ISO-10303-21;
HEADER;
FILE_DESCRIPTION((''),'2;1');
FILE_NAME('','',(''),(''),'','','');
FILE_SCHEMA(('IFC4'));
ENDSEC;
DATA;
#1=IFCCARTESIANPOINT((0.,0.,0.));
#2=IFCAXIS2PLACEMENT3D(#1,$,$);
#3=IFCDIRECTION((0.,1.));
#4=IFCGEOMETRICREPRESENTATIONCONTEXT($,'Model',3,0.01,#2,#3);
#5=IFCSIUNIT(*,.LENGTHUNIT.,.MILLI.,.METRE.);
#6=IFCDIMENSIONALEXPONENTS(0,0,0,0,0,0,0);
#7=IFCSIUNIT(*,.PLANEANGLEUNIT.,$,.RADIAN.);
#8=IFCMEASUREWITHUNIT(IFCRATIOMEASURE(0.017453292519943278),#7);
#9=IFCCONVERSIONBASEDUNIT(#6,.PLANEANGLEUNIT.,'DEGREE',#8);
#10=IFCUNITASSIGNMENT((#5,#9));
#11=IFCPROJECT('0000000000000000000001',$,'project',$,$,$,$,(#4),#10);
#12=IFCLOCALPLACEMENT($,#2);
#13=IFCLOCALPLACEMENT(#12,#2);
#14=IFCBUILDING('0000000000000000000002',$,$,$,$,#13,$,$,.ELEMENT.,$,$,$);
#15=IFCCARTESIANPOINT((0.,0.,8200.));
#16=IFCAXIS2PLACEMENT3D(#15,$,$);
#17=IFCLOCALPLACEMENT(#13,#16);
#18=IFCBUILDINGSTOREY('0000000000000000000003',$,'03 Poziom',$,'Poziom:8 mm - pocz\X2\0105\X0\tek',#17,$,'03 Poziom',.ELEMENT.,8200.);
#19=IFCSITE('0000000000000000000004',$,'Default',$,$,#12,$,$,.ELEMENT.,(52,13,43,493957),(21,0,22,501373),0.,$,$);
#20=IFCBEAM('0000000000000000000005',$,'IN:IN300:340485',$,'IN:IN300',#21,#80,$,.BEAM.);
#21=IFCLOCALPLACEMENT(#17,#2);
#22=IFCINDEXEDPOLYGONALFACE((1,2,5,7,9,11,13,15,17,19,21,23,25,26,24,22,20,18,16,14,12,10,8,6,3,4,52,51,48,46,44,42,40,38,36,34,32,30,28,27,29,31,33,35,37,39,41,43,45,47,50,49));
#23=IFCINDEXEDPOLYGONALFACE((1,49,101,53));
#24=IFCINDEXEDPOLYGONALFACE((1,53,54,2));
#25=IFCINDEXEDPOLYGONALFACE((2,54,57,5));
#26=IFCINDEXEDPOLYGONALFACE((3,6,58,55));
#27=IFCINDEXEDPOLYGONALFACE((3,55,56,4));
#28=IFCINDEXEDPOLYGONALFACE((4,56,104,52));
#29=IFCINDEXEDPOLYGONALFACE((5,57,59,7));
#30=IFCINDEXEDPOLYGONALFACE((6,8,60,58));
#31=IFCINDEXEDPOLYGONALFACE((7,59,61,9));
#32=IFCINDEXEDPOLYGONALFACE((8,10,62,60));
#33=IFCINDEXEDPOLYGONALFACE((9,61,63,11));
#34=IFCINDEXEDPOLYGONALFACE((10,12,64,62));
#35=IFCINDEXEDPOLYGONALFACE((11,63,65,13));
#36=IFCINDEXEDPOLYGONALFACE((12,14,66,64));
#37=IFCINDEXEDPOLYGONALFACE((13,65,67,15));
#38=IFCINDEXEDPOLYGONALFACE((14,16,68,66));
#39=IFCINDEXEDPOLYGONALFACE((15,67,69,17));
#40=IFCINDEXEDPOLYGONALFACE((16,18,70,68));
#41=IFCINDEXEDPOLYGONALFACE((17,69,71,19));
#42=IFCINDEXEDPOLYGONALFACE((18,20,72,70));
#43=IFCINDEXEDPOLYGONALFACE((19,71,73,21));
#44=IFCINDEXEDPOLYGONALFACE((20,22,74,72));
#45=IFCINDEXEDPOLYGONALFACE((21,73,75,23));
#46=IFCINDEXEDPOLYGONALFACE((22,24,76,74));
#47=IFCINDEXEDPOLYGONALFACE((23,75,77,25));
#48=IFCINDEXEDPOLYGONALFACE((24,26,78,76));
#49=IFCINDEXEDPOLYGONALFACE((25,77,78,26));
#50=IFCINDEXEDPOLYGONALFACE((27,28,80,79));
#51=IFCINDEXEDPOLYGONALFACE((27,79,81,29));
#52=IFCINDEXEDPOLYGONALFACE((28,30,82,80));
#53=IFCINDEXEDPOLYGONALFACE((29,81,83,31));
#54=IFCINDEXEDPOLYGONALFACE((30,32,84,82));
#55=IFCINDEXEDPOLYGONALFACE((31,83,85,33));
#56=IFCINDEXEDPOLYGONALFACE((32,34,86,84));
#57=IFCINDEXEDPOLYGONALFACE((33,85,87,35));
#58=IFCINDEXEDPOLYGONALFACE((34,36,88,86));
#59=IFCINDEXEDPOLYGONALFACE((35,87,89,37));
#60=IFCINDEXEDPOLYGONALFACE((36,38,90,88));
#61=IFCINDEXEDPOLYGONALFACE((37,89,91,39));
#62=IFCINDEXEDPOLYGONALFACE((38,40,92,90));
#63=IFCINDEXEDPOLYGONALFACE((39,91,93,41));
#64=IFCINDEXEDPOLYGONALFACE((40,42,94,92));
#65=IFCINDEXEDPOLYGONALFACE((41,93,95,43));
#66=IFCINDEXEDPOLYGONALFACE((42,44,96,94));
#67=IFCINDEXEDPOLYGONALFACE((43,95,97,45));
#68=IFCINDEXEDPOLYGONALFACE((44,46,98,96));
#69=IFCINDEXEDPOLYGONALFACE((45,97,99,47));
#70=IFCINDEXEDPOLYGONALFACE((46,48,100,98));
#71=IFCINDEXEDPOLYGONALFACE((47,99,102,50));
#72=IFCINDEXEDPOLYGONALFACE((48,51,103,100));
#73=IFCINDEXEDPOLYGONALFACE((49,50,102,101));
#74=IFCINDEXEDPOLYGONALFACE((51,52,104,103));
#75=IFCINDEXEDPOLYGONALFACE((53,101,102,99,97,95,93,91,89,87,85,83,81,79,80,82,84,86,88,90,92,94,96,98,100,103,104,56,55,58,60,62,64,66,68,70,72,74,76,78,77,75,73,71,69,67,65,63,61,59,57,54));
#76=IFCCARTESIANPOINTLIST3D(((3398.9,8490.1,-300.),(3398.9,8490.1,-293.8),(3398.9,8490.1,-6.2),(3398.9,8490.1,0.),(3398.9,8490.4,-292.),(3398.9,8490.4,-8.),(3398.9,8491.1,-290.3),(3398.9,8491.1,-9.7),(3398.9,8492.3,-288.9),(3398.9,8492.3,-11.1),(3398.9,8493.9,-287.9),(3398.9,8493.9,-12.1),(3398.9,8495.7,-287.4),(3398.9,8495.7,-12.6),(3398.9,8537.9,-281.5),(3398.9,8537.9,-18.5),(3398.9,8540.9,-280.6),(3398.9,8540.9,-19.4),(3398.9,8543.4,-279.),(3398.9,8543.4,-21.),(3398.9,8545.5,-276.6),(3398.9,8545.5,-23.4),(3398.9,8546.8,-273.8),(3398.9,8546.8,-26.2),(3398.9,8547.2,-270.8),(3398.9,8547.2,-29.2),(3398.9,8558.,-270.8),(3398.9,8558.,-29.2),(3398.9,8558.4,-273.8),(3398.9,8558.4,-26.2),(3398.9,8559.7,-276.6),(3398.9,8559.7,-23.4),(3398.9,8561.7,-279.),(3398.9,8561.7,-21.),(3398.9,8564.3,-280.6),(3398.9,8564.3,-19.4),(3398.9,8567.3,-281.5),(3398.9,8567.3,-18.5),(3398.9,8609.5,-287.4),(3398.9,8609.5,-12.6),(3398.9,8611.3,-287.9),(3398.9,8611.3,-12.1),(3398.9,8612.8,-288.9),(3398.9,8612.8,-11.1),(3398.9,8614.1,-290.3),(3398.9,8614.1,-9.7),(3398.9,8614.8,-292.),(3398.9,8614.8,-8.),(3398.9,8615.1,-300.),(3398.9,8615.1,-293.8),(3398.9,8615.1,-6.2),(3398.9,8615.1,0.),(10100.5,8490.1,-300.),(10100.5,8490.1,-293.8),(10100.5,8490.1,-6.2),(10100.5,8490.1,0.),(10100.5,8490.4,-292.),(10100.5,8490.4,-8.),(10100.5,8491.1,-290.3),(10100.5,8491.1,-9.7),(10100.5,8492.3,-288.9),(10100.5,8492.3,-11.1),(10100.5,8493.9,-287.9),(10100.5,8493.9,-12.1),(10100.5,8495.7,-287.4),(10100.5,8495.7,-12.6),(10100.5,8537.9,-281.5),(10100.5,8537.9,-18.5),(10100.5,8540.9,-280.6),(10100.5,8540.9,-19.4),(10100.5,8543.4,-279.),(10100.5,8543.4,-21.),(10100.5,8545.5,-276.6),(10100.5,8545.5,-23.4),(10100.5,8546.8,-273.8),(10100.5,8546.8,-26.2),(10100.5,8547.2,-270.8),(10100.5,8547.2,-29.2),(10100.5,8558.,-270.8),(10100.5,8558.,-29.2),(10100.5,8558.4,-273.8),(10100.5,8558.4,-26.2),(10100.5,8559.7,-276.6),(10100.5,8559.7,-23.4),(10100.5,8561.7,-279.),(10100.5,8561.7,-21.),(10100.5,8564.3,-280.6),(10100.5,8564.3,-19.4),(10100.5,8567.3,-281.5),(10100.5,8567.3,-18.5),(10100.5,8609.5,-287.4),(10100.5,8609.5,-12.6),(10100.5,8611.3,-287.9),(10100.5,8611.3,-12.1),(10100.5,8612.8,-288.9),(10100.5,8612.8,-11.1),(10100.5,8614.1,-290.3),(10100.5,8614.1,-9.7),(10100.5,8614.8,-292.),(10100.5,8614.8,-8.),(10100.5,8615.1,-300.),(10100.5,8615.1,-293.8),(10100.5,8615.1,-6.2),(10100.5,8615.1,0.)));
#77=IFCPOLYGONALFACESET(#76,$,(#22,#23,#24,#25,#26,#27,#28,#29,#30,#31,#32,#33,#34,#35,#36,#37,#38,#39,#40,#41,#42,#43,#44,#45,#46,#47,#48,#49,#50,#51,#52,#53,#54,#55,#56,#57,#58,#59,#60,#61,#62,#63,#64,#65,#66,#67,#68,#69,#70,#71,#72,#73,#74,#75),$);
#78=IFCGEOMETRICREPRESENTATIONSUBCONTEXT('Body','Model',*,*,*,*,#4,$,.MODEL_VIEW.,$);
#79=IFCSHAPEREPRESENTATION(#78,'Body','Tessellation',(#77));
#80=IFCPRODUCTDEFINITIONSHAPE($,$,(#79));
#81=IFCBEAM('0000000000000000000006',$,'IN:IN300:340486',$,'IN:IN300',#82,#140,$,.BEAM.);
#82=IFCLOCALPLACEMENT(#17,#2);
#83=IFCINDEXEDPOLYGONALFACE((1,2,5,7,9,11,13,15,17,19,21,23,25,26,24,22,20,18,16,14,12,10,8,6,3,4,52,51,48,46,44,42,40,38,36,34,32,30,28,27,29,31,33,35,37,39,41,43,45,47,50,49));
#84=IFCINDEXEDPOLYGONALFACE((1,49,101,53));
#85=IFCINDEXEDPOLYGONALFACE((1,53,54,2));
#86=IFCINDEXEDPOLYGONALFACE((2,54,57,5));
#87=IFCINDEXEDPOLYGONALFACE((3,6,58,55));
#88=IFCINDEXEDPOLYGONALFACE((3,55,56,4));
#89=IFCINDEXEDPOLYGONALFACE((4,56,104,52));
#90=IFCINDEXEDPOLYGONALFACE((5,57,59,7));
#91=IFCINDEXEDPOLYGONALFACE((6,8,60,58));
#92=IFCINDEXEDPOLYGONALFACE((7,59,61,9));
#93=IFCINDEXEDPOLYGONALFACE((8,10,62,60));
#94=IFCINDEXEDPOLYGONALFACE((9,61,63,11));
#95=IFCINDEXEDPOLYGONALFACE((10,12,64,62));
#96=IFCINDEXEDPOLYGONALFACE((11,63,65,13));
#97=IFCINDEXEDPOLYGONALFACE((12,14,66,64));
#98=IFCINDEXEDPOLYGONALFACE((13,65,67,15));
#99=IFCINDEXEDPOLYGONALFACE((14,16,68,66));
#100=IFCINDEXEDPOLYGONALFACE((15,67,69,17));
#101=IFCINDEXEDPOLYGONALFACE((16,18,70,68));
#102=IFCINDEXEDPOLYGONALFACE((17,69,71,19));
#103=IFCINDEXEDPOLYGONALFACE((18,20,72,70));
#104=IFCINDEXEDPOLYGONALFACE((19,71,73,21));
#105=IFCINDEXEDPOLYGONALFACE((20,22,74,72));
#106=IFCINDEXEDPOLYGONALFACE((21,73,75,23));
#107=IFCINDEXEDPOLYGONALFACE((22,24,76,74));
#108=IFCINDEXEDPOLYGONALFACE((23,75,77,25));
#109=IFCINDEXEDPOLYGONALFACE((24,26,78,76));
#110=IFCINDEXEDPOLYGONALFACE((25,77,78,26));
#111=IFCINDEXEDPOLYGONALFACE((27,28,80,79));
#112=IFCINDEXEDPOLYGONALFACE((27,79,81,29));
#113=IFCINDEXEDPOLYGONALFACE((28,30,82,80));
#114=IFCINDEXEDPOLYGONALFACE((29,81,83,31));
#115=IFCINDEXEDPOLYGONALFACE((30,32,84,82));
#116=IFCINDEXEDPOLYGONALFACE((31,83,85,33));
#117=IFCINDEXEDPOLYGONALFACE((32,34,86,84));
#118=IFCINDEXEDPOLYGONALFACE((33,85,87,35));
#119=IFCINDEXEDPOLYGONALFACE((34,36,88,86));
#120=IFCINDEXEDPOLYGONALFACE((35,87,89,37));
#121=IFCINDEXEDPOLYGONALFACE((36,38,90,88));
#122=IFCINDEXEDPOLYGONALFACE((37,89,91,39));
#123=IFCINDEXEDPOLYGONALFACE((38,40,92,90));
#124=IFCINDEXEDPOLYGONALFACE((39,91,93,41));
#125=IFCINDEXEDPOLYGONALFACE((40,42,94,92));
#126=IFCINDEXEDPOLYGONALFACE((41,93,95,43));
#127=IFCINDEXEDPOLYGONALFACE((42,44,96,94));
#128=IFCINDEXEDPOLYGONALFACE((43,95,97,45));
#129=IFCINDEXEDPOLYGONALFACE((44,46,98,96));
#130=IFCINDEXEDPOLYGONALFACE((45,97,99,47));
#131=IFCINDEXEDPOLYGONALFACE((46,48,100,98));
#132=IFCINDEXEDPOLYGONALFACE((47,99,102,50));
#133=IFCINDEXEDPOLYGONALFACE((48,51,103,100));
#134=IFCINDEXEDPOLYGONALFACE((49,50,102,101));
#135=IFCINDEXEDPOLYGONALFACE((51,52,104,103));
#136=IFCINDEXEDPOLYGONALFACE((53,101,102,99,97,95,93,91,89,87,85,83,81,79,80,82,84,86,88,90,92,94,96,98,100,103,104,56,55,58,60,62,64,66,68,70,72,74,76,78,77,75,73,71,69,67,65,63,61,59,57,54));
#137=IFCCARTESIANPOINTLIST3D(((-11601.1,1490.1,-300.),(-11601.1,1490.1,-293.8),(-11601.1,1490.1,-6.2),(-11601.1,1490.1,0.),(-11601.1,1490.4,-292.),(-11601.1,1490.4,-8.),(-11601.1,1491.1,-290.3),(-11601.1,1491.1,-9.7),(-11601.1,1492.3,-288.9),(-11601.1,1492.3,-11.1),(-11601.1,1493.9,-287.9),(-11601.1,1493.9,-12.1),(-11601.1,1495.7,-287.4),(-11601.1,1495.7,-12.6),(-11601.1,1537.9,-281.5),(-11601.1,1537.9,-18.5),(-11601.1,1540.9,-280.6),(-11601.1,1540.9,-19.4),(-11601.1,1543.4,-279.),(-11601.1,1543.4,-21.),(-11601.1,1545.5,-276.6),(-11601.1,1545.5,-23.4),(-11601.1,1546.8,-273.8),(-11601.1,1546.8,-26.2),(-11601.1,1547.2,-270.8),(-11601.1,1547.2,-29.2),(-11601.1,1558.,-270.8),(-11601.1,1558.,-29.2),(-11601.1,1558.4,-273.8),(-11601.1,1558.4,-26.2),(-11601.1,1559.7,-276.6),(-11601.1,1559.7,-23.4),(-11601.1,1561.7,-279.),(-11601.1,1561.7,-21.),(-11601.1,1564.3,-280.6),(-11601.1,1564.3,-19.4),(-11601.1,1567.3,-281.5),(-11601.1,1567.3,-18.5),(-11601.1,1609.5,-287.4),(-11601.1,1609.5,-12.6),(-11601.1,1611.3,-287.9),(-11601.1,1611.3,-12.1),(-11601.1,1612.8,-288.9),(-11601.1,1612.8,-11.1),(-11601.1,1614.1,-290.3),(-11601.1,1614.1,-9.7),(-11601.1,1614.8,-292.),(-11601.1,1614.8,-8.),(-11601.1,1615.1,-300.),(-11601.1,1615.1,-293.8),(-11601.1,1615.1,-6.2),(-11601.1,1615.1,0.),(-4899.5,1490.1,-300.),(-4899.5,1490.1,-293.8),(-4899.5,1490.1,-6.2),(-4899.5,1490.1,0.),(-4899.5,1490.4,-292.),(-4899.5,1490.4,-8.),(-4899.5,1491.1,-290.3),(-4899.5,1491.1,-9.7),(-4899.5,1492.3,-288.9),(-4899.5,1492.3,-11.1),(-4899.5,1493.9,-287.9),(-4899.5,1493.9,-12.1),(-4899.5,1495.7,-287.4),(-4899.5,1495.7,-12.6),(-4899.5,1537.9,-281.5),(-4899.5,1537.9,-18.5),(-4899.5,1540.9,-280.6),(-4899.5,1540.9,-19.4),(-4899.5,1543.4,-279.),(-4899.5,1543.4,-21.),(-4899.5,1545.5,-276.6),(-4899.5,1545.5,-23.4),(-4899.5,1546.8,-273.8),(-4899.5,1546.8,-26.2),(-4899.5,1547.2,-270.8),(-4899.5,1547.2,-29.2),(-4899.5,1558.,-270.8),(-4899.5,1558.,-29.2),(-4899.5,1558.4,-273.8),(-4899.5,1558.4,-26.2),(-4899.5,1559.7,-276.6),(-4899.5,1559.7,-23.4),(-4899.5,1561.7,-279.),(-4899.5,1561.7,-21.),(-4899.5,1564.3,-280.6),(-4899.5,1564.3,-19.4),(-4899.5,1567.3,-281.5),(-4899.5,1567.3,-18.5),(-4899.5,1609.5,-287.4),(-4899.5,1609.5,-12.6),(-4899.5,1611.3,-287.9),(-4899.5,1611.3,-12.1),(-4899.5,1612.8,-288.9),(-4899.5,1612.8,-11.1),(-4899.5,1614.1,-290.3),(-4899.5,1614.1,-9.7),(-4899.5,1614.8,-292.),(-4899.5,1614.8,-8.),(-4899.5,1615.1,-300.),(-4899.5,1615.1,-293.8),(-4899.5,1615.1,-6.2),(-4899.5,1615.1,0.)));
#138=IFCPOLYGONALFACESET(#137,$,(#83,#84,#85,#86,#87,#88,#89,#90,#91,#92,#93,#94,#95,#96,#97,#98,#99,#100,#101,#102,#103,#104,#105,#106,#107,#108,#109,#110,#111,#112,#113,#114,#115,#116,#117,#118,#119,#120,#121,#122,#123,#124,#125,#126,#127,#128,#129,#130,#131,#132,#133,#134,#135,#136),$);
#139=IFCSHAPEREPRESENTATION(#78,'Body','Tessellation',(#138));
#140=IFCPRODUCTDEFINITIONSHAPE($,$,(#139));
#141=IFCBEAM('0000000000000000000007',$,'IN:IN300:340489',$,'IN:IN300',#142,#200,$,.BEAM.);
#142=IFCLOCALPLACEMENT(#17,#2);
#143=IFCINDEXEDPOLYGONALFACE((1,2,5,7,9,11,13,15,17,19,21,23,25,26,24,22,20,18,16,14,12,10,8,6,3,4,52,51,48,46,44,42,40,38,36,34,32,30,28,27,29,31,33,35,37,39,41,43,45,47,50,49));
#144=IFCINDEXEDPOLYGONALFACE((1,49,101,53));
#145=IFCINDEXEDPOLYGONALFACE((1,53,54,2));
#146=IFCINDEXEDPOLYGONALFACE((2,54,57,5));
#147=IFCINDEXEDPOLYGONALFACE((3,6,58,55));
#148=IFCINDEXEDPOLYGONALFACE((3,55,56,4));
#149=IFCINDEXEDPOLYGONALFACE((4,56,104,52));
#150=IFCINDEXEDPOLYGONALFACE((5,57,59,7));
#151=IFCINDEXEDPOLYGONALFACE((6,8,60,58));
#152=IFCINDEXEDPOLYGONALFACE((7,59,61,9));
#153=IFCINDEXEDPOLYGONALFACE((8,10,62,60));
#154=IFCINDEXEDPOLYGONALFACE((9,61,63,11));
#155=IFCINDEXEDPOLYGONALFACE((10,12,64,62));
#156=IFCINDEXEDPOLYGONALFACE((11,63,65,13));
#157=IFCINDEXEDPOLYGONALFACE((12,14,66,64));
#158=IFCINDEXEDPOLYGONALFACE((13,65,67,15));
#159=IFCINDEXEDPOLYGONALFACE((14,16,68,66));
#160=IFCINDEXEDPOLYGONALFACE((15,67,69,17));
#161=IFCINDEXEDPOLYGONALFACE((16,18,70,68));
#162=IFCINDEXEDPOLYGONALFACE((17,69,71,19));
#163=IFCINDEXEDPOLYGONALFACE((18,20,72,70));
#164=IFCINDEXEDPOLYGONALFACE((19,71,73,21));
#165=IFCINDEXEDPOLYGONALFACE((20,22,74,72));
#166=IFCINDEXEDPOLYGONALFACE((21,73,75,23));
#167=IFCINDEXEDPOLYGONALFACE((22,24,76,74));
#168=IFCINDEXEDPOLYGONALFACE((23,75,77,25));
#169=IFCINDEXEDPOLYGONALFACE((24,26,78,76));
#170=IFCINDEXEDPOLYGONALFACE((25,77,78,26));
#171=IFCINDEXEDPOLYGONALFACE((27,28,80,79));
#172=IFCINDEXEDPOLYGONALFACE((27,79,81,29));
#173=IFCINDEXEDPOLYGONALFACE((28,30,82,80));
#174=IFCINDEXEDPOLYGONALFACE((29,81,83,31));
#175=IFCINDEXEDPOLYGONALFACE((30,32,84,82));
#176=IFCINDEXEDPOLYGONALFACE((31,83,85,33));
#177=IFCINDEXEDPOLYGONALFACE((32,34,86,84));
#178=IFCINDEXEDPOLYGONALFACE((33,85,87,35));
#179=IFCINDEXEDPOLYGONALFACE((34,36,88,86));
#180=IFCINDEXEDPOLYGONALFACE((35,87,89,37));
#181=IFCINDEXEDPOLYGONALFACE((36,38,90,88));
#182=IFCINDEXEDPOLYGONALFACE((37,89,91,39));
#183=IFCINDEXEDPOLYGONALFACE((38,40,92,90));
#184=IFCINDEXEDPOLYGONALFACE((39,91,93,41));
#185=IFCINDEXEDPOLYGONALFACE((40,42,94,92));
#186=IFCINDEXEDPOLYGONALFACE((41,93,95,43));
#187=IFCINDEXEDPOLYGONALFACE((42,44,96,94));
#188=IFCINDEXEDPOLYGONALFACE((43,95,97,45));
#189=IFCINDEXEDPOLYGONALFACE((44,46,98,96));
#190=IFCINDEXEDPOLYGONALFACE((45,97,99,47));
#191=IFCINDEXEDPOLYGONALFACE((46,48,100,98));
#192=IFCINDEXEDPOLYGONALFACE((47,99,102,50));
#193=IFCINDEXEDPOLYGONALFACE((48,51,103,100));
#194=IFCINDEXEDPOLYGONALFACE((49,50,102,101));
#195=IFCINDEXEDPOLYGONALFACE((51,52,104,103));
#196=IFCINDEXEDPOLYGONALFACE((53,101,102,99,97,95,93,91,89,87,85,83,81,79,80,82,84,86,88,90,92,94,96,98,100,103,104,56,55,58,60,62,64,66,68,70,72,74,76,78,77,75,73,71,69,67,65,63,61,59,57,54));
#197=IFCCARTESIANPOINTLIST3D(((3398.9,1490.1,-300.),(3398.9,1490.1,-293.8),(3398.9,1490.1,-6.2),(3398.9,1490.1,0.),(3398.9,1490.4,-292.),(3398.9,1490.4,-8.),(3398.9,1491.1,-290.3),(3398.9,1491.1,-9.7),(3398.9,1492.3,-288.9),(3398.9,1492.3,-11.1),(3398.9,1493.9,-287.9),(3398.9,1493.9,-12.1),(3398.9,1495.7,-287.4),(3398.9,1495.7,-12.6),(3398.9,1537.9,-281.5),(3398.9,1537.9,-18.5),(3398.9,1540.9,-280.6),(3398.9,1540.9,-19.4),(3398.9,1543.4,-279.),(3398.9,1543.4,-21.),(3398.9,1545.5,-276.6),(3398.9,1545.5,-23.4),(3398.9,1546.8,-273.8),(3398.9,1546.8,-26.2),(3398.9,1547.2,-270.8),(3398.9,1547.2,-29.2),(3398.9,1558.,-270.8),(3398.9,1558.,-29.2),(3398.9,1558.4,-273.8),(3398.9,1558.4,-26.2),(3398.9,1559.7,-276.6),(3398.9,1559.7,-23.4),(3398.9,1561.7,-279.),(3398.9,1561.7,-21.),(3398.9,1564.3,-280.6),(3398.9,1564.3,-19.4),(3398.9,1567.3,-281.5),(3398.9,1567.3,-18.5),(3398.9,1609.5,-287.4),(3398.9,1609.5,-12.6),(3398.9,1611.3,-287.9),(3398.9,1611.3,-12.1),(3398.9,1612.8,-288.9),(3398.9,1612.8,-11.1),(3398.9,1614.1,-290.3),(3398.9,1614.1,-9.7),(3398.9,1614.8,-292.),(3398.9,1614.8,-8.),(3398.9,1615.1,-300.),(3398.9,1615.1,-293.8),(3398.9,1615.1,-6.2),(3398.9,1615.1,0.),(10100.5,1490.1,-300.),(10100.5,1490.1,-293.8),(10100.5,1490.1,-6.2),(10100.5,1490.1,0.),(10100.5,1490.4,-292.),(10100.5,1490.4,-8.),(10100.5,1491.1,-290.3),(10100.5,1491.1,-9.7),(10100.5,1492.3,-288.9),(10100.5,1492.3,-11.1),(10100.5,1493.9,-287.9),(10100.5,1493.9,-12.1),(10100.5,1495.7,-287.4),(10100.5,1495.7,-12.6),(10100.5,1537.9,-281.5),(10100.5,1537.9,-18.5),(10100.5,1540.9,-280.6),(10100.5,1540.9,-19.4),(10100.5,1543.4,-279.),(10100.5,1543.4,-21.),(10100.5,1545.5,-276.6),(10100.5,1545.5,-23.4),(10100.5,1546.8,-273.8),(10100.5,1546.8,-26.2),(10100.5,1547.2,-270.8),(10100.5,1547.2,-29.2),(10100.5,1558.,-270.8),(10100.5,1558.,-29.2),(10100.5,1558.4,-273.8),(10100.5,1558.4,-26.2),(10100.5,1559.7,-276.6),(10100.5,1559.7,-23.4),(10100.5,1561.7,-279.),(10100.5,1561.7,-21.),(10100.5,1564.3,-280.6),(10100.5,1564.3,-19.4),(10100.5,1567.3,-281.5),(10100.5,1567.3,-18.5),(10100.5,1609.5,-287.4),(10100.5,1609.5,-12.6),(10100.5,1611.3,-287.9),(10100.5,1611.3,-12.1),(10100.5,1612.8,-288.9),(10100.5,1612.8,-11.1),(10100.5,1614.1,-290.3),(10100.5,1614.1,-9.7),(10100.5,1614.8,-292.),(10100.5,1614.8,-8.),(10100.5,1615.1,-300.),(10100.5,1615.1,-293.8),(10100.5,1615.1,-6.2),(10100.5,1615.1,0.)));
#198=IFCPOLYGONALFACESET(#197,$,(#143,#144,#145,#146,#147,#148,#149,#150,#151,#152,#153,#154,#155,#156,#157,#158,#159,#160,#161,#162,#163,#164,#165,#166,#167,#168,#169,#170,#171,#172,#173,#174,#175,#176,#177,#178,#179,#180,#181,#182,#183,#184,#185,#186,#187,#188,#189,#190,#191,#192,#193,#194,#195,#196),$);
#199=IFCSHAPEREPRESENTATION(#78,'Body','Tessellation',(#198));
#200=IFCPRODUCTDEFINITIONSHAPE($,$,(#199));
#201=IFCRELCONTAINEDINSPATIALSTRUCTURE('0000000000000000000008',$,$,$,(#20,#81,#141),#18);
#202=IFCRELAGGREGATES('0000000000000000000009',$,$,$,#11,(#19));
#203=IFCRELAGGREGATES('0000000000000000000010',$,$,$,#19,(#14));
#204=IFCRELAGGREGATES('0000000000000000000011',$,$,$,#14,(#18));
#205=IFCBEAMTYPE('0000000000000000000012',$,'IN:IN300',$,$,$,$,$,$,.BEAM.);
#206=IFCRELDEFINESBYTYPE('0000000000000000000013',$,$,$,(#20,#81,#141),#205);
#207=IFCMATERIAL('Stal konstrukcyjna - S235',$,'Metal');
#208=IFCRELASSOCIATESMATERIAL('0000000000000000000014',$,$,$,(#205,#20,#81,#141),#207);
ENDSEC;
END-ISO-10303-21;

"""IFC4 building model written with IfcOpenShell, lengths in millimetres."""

from ifc_helpers import new_model, entity, si_unit, converted_unit, direction, frame, origin, place, context, subcontext, project, spatial, line, arc, indexed_curve, outline, extrude, source, transform, mapped, material, type_object, type_shapes, element, save


model = new_model("IFC4")

# Units and contexts
model_context = context("Model", 3, precision=0.01, world=origin(), true_north=direction((0.0, 1.0)))
body_context = subcontext(model_context, "Body", "Model", "MODEL_VIEW")
ifc_project = project(units=[si_unit("LENGTHUNIT", "METRE", prefix="MILLI"), converted_unit("PLANEANGLEUNIT", "DEGREE", entity("IfcRatioMeasure", 0.017453292519943278), si_unit("PLANEANGLEUNIT", "RADIAN"), dimensions=[0, 0, 0, 0, 0, 0, 0])], contexts=[model_context])

# Site, building, storey
site_placement = place(None, origin())
site = spatial("IfcSite", under=ifc_project, at=site_placement, Name="Default", CompositionType="ELEMENT", RefLatitude=(52, 13, 43, 493957), RefLongitude=(21, 0, 22, 501373), RefElevation=0.0)
building_placement = place(site_placement, origin())
building = spatial("IfcBuilding", under=site, at=building_placement, CompositionType="ELEMENT")
storey_placement = place(building_placement, frame((0.0, 0.0, 8200.0)))
storey = spatial("IfcBuildingStorey", under=building, at=storey_placement, Name="03 Poziom", ObjectType="Poziom:8 mm - początek", LongName="03 Poziom", CompositionType="ELEMENT", Elevation=8200.0)

# Shared definitions
ifc_material_1 = material(Name="Stal konstrukcyjna - S235", Category="Metal")

# Beams
beam_type_1 = type_object("IfcBeamType", Name="IN:IN300", PredefinedType="BEAM", material=ifc_material_1)
shared_shape_1 = source(origin(), body_context, "Body", "SweptSolid", [
    extrude(outline(indexed_curve([(143.8, -62.5), (150.0, -62.5), (150.0, 62.5), (143.8, 62.5), (139.6, 60.9), (137.4, 56.9), (131.5, 14.7), (127.9, 8.1), (120.8, 5.4), (-120.8, 5.4), (-127.9, 8.1), (-131.5, 14.7), (-137.4, 56.9), (-139.6, 60.9), (-143.8, 62.5), (-150.0, 62.5), (-150.0, -62.5), (-143.8, -62.5), (-139.6, -60.9), (-137.4, -56.9), (-131.5, -14.7), (-127.9, -8.1), (-120.8, -5.4), (120.8, -5.4), (127.9, -8.1), (131.5, -14.7), (137.4, -56.9), (139.6, -60.9)], segments=[line(1, 2, 3, 4), arc(4, 5, 6), line(6, 7), arc(7, 8, 9), line(9, 10), arc(10, 11, 12), line(12, 13), arc(13, 14, 15), line(15, 16, 17, 18), arc(18, 19, 20), line(20, 21), arc(21, 22, 23), line(23, 24), arc(24, 25, 26), line(26, 27), arc(27, 28, 1)], self_intersect=False)), frame((-3350.8, 0.0, 0.0), z_axis=(1.0, 0.0, 0.0), x_axis=(0.0, 0.0, -1.0)), (0.0, 0.0, 1.0), 6701.6),
])
type_shapes(beam_type_1, [shared_shape_1])
for number, where, name in (
    (1, (6749.7, 8552.6, -150.0), "IN:IN300:340485"),
    (2, (-8250.3, 1552.6, -150.0), "IN:IN300:340486"),
    (3, (6749.7, 1552.6, -150.0), "IN:IN300:340489"),
):
    element("IfcBeam", number, at=place(storey_placement, frame(where)), inside=storey, type_object=beam_type_1, material=ifc_material_1, Name=name, ObjectType="IN:IN300", PredefinedType="BEAM", context=body_context, shape_type="MappedRepresentation", body=[
        mapped(shared_shape_1, transform((0.0, 0.0, 0.0), scale=1.0)),
    ])

save(model, "model.ifc")
